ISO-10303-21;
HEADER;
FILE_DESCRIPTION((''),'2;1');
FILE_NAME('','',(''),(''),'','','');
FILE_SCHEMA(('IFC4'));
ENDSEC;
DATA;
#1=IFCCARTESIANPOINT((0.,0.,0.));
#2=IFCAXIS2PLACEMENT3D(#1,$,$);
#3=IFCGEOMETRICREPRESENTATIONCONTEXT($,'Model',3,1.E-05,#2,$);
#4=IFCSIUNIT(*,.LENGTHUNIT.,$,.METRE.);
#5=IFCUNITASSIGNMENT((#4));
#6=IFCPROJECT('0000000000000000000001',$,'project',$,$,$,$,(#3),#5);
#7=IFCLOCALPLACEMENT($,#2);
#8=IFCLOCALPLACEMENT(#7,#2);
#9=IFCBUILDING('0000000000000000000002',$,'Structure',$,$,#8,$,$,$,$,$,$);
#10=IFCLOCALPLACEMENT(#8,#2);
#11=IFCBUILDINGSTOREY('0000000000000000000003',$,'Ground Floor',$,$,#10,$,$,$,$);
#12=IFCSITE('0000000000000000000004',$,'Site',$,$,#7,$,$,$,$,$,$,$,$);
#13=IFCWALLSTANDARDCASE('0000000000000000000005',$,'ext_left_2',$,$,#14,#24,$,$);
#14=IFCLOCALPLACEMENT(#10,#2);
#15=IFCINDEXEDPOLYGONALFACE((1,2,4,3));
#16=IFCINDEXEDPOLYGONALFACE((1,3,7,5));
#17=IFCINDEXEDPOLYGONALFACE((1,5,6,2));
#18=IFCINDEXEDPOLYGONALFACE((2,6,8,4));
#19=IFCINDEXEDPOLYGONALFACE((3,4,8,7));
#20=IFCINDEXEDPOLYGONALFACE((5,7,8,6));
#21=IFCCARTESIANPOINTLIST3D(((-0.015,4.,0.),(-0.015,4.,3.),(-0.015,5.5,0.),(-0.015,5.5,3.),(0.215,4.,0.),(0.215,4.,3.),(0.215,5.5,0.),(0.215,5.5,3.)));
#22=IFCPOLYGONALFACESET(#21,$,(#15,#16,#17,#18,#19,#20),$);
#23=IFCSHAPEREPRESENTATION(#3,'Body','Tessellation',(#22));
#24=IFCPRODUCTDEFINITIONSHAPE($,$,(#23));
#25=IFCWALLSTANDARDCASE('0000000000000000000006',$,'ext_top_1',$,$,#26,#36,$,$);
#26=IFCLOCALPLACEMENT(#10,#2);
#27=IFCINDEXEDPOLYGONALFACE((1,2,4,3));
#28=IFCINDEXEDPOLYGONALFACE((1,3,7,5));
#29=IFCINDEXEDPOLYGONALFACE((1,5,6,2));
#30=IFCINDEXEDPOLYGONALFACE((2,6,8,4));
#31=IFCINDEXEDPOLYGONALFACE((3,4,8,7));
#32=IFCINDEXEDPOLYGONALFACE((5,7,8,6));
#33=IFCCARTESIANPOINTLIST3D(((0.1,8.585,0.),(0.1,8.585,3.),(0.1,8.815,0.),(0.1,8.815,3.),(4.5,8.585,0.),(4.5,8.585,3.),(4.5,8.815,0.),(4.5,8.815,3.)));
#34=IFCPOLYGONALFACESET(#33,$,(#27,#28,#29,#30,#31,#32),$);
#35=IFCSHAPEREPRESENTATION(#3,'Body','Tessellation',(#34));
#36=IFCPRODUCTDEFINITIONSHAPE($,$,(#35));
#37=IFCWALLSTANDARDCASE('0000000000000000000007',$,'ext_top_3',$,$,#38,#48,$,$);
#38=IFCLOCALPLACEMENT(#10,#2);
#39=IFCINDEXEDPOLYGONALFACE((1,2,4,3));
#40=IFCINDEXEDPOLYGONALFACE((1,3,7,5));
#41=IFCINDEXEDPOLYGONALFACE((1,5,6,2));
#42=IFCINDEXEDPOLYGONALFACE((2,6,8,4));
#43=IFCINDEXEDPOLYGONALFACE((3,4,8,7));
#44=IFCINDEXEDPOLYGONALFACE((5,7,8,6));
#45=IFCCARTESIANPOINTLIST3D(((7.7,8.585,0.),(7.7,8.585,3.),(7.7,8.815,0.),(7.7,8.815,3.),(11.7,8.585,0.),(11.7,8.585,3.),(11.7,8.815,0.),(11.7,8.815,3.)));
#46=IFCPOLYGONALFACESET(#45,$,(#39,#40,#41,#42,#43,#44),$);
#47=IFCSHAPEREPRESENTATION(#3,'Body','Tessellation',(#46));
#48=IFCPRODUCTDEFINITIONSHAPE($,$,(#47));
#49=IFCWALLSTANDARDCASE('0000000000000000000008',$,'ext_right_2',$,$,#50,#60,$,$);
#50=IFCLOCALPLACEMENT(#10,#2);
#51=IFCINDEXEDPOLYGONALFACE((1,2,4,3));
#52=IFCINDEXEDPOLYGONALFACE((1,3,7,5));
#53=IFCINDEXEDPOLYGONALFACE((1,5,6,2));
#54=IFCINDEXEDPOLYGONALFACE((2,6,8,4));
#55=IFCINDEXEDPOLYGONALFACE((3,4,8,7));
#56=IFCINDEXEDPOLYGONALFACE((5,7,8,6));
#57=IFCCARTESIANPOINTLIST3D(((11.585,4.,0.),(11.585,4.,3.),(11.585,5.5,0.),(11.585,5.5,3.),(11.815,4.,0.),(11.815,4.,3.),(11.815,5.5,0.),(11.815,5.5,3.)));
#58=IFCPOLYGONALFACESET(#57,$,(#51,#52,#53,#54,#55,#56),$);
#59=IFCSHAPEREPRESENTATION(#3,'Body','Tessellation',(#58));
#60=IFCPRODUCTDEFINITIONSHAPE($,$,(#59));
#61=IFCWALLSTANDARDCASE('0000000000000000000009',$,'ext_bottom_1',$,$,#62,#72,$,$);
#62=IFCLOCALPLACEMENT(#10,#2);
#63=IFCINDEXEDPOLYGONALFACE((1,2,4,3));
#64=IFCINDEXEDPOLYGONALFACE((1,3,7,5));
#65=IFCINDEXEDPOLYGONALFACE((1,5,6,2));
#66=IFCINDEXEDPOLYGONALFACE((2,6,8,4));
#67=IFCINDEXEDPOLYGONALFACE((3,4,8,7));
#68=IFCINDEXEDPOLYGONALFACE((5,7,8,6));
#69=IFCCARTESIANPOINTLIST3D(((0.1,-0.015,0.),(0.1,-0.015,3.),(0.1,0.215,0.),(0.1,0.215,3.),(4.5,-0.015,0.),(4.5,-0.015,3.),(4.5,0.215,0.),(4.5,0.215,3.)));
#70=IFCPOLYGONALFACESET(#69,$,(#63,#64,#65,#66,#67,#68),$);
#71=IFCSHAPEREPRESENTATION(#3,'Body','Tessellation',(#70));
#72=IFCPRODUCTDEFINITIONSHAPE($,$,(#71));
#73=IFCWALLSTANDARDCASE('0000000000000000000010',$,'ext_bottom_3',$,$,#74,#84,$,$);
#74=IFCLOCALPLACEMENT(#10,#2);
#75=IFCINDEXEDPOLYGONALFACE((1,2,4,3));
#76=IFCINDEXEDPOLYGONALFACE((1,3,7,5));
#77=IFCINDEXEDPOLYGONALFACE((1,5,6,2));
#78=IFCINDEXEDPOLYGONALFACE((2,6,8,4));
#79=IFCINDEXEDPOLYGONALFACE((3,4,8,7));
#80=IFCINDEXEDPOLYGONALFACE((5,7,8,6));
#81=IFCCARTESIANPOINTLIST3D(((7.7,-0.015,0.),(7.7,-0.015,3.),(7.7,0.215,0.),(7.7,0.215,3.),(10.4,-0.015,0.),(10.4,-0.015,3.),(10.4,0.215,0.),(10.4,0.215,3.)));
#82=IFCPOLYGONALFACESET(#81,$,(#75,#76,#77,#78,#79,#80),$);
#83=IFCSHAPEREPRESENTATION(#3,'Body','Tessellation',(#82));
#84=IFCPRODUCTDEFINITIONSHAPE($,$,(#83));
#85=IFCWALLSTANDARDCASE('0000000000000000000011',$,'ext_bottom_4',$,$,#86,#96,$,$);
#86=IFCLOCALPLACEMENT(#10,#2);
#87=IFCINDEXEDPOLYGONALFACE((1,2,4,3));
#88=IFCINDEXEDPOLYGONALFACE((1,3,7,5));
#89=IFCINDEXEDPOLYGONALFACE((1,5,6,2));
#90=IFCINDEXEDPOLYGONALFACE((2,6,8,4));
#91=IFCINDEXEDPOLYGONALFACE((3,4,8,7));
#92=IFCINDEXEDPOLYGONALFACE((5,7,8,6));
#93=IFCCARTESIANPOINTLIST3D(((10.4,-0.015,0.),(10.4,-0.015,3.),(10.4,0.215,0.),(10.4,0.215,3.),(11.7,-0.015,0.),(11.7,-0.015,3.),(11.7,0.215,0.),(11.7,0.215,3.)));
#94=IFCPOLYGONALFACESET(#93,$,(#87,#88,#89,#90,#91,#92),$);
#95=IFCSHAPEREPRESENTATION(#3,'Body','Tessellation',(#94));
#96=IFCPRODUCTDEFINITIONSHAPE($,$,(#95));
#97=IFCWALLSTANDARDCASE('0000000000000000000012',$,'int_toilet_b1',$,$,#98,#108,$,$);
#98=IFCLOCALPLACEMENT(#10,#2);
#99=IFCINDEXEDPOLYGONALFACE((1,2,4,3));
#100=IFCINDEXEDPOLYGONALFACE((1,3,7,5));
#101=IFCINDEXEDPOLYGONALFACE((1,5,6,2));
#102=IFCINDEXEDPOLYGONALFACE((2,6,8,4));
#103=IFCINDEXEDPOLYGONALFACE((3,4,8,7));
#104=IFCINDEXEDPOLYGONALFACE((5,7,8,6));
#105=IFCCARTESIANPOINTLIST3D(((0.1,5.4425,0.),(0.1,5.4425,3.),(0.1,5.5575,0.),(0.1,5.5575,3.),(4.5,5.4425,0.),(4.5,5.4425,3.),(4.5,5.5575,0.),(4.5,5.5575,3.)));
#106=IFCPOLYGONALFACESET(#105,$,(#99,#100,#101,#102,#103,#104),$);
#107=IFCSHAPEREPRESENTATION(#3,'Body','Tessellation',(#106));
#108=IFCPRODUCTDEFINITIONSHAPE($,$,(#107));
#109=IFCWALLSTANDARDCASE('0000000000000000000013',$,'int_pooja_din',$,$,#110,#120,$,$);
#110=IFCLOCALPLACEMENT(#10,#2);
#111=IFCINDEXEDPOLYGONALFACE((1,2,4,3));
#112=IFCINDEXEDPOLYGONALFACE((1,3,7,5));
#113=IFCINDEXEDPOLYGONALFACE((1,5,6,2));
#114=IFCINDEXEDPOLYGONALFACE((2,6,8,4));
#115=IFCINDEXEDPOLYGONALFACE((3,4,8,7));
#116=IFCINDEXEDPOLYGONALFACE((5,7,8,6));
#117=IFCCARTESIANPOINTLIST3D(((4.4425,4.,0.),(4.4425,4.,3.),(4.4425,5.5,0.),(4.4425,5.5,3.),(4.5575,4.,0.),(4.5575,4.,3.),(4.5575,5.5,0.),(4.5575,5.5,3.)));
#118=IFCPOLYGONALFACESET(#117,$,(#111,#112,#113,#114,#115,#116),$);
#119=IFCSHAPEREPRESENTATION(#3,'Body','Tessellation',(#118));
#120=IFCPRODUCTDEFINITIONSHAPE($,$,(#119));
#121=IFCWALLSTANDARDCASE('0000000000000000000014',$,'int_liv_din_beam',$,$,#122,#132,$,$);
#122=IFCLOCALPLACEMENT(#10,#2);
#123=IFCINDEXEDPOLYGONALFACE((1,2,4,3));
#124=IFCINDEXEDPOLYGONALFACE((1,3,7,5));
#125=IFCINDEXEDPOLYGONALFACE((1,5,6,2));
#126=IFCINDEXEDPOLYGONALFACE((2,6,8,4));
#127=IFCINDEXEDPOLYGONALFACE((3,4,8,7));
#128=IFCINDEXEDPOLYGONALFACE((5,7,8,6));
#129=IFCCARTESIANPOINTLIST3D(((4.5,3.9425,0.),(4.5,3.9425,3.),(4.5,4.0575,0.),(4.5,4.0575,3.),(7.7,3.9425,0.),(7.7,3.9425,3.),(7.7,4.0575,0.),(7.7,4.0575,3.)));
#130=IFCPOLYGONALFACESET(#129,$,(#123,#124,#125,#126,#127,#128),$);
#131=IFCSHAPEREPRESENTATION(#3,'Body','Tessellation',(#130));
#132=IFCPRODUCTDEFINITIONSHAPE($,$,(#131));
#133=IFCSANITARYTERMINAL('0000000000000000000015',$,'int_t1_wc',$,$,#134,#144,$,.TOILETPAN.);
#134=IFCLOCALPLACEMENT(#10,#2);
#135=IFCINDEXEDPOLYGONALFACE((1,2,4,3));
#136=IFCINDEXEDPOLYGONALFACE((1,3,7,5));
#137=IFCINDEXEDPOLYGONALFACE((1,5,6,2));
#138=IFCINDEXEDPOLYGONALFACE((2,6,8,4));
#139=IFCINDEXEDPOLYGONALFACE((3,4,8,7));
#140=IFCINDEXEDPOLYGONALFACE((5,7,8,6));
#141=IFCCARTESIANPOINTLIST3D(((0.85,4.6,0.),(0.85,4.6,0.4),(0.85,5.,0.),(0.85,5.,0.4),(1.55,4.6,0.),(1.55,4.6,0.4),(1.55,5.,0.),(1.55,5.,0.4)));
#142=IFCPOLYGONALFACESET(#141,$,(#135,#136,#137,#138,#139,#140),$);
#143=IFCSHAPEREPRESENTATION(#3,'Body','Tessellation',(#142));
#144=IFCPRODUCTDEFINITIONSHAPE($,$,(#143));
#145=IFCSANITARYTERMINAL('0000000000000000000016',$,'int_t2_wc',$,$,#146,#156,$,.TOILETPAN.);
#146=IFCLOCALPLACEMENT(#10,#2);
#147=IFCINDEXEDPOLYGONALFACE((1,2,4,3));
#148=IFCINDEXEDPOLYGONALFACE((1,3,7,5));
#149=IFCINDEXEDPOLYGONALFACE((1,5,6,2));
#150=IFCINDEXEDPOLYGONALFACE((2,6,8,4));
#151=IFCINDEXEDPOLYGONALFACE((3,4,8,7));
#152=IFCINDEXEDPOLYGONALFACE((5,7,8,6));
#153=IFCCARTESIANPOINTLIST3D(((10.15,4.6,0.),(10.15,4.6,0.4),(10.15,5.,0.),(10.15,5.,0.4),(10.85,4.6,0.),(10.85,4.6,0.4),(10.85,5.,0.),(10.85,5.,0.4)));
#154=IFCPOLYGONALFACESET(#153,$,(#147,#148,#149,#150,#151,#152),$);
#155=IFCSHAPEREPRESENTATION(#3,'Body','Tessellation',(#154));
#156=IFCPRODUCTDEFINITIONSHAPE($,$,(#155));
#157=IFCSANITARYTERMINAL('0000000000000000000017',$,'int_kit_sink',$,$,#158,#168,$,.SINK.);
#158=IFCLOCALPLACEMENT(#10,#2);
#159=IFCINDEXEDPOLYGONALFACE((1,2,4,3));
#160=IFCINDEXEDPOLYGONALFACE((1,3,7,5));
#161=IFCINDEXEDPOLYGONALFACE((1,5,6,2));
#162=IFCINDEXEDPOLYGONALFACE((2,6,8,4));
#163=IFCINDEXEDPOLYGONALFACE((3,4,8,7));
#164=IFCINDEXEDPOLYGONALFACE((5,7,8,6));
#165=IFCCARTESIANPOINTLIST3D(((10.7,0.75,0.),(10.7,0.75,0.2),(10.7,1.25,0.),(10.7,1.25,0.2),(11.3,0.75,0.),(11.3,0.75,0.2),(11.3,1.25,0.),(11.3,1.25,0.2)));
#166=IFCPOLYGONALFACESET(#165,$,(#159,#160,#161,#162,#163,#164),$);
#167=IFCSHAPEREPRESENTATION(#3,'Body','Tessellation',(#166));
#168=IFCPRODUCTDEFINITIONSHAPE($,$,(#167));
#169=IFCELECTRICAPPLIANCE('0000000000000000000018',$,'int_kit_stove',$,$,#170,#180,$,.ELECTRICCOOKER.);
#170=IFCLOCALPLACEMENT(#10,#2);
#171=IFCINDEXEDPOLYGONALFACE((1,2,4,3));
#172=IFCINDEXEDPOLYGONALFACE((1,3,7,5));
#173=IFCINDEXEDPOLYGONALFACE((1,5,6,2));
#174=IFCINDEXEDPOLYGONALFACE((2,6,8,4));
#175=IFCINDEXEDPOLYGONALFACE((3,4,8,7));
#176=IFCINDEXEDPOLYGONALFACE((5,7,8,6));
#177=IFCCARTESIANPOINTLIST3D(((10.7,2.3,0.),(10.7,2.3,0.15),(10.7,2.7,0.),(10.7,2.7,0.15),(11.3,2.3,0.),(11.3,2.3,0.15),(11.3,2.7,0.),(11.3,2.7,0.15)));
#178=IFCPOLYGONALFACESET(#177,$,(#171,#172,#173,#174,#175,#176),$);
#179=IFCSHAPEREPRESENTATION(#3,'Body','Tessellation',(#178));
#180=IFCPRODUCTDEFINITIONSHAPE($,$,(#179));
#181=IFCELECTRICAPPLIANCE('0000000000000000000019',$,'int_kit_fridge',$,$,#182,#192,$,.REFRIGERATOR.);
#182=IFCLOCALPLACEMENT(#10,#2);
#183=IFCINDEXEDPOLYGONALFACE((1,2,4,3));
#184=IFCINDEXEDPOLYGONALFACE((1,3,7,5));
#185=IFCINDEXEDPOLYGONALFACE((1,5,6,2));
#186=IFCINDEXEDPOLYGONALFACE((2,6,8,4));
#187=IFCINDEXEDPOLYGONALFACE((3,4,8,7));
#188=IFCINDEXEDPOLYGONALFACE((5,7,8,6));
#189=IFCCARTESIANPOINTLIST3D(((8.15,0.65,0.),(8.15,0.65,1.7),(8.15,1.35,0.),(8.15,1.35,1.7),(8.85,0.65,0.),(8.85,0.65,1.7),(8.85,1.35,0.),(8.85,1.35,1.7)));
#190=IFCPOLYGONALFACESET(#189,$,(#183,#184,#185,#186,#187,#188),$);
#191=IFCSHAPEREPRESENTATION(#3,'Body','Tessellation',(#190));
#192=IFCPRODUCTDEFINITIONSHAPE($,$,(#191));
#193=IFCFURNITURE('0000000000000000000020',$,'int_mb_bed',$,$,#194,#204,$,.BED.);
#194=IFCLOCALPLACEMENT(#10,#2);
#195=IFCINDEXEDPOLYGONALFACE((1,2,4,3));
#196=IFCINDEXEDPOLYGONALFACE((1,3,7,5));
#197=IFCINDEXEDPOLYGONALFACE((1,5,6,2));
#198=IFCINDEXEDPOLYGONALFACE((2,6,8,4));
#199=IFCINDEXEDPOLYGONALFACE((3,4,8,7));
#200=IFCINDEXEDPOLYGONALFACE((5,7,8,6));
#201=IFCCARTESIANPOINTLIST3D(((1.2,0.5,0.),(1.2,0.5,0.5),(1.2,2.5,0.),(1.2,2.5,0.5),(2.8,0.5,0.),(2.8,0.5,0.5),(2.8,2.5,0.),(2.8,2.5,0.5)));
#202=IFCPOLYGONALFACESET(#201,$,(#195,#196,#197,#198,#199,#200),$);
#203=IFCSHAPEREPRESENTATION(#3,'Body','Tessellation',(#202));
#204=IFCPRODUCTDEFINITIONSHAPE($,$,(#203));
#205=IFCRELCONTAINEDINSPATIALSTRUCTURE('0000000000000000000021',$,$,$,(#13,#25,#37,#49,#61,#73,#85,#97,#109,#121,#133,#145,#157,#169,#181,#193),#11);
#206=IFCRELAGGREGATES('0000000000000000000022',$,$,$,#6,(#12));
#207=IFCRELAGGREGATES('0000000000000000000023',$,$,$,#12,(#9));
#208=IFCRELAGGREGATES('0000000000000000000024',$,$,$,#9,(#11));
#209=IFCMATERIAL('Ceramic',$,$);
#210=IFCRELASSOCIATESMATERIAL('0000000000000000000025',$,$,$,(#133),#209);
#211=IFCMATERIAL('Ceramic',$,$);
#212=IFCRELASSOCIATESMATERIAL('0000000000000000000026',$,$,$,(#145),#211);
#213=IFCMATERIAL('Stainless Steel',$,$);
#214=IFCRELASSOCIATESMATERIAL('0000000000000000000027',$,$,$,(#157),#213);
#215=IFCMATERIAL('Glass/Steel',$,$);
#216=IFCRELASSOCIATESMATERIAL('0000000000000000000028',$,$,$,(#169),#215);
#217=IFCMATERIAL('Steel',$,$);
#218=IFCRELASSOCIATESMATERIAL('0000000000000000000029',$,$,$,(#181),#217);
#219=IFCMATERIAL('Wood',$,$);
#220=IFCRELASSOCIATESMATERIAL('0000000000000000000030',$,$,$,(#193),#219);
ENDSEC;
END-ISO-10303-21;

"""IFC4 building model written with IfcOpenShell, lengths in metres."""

from ifc_helpers import new_model, si_unit, frame, origin, place, context, project, spatial, polyline, outline, extrude, material, element, save


model = new_model("IFC4")

# Units and contexts
model_context = context("Model", 3, precision=1e-05, world=origin())
ifc_project = project(units=[si_unit("LENGTHUNIT", "METRE")], contexts=[model_context])

# Site, building, storey
site_placement = place(None, origin())
site = spatial("IfcSite", under=ifc_project, at=site_placement, Name="Site")
building_placement = place(site_placement, origin())
building = spatial("IfcBuilding", under=site, at=building_placement, Name="Structure")
storey_placement = place(building_placement, origin())
storey = spatial("IfcBuildingStorey", under=building, at=storey_placement, Name="Ground Floor")

# Walls
wall_1_placement = place(storey_placement, frame((0.1, 4.0, 0.0), x_axis=(0.0, 1.0, 0.0)))
element("IfcWallStandardCase", 1, at=wall_1_placement, inside=storey, Name="ext_left_2", context=model_context, shape_type="SweptSolid", body=[
    extrude(outline(polyline([(0.0, -0.115), (1.5, -0.115), (1.5, 0.115), (0.0, 0.115), (0.0, -0.115)])), origin(), (0.0, 0.0, 1.0), 3.0),
])
wall_2_placement = place(storey_placement, frame((0.1, 8.7, 0.0), x_axis=(1.0, 0.0, 0.0)))
element("IfcWallStandardCase", 2, at=wall_2_placement, inside=storey, Name="ext_top_1", context=model_context, shape_type="SweptSolid", body=[
    extrude(outline(polyline([(0.0, -0.115), (4.4, -0.115), (4.4, 0.115), (0.0, 0.115), (0.0, -0.115)])), origin(), (0.0, 0.0, 1.0), 3.0),
])
wall_3_placement = place(storey_placement, frame((7.7, 8.7, 0.0), x_axis=(1.0, 0.0, 0.0)))
element("IfcWallStandardCase", 3, at=wall_3_placement, inside=storey, Name="ext_top_3", context=model_context, shape_type="SweptSolid", body=[
    extrude(outline(polyline([(0.0, -0.115), (4.0, -0.115), (4.0, 0.115), (0.0, 0.115), (0.0, -0.115)])), origin(), (0.0, 0.0, 1.0), 3.0),
])
wall_4_placement = place(storey_placement, frame((11.7, 5.5, 0.0), x_axis=(0.0, -1.0, 0.0)))
element("IfcWallStandardCase", 4, at=wall_4_placement, inside=storey, Name="ext_right_2", context=model_context, shape_type="SweptSolid", body=[
    extrude(outline(polyline([(0.0, -0.115), (1.5, -0.115), (1.5, 0.115), (0.0, 0.115), (0.0, -0.115)])), origin(), (0.0, 0.0, 1.0), 3.0),
])
wall_5_placement = place(storey_placement, frame((0.1, 0.1, 0.0), x_axis=(1.0, 0.0, 0.0)))
element("IfcWallStandardCase", 5, at=wall_5_placement, inside=storey, Name="ext_bottom_1", context=model_context, shape_type="SweptSolid", body=[
    extrude(outline(polyline([(0.0, -0.115), (4.4, -0.115), (4.4, 0.115), (0.0, 0.115), (0.0, -0.115)])), origin(), (0.0, 0.0, 1.0), 3.0),
])
wall_6_placement = place(storey_placement, frame((7.7, 0.1, 0.0), x_axis=(1.0, 0.0, 0.0)))
element("IfcWallStandardCase", 6, at=wall_6_placement, inside=storey, Name="ext_bottom_3", context=model_context, shape_type="SweptSolid", body=[
    extrude(outline(polyline([(0.0, -0.115), (2.7, -0.115), (2.7, 0.115), (0.0, 0.115), (0.0, -0.115)])), origin(), (0.0, 0.0, 1.0), 3.0),
])
wall_7_placement = place(storey_placement, frame((10.4, 0.1, 0.0), x_axis=(1.0, 0.0, 0.0)))
element("IfcWallStandardCase", 7, at=wall_7_placement, inside=storey, Name="ext_bottom_4", context=model_context, shape_type="SweptSolid", body=[
    extrude(outline(polyline([(0.0, -0.115), (1.3, -0.115), (1.3, 0.115), (0.0, 0.115), (0.0, -0.115)])), origin(), (0.0, 0.0, 1.0), 3.0),
])
wall_8_placement = place(storey_placement, frame((0.1, 5.5, 0.0), x_axis=(1.0, 0.0, 0.0)))
element("IfcWallStandardCase", 8, at=wall_8_placement, inside=storey, Name="int_toilet_b1", context=model_context, shape_type="SweptSolid", body=[
    extrude(outline(polyline([(0.0, -0.0575), (4.4, -0.0575), (4.4, 0.0575), (0.0, 0.0575), (0.0, -0.0575)])), origin(), (0.0, 0.0, 1.0), 3.0),
])
wall_9_placement = place(storey_placement, frame((4.5, 4.0, 0.0), x_axis=(0.0, 1.0, 0.0)))
element("IfcWallStandardCase", 9, at=wall_9_placement, inside=storey, Name="int_pooja_din", context=model_context, shape_type="SweptSolid", body=[
    extrude(outline(polyline([(0.0, -0.0575), (1.5, -0.0575), (1.5, 0.0575), (0.0, 0.0575), (0.0, -0.0575)])), origin(), (0.0, 0.0, 1.0), 3.0),
])
wall_10_placement = place(storey_placement, frame((4.5, 4.0, 0.0), x_axis=(1.0, 0.0, 0.0)))
element("IfcWallStandardCase", 10, at=wall_10_placement, inside=storey, Name="int_liv_din_beam", context=model_context, shape_type="SweptSolid", body=[
    extrude(outline(polyline([(0.0, -0.0575), (3.2, -0.0575), (3.2, 0.0575), (0.0, 0.0575), (0.0, -0.0575)])), origin(), (0.0, 0.0, 1.0), 3.0),
])

# Sanitary terminals
ifc_material_1 = material(Name="Ceramic")
sanitary_terminal_1_placement = place(storey_placement, frame((1.2, 4.8, 0.0)))
element("IfcSanitaryTerminal", 11, at=sanitary_terminal_1_placement, inside=storey, material=ifc_material_1, Name="int_t1_wc", PredefinedType="TOILETPAN", context=model_context, shape_type="SweptSolid", body=[
    extrude(outline(polyline([(-0.35, -0.2), (0.35, -0.2), (0.35, 0.2), (-0.35, 0.2), (-0.35, -0.2)])), origin(), (0.0, 0.0, 1.0), 0.4),
])
ifc_material_2 = material(Name="Ceramic")
sanitary_terminal_2_placement = place(storey_placement, frame((10.5, 4.8, 0.0)))
element("IfcSanitaryTerminal", 12, at=sanitary_terminal_2_placement, inside=storey, material=ifc_material_2, Name="int_t2_wc", PredefinedType="TOILETPAN", context=model_context, shape_type="SweptSolid", body=[
    extrude(outline(polyline([(-0.35, -0.2), (0.35, -0.2), (0.35, 0.2), (-0.35, 0.2), (-0.35, -0.2)])), origin(), (0.0, 0.0, 1.0), 0.4),
])
ifc_material_3 = material(Name="Stainless Steel")
sanitary_terminal_3_placement = place(storey_placement, frame((11.0, 1.0, 0.0)))
element("IfcSanitaryTerminal", 13, at=sanitary_terminal_3_placement, inside=storey, material=ifc_material_3, Name="int_kit_sink", PredefinedType="SINK", context=model_context, shape_type="SweptSolid", body=[
    extrude(outline(polyline([(-0.3, -0.25), (0.3, -0.25), (0.3, 0.25), (-0.3, 0.25), (-0.3, -0.25)])), origin(), (0.0, 0.0, 1.0), 0.2),
])

# Electric appliances
ifc_material_4 = material(Name="Glass/Steel")
electric_appliance_1_placement = place(storey_placement, frame((11.0, 2.5, 0.0)))
element("IfcElectricAppliance", 14, at=electric_appliance_1_placement, inside=storey, material=ifc_material_4, Name="int_kit_stove", PredefinedType="ELECTRICCOOKER", context=model_context, shape_type="SweptSolid", body=[
    extrude(outline(polyline([(-0.3, -0.2), (0.3, -0.2), (0.3, 0.2), (-0.3, 0.2), (-0.3, -0.2)])), origin(), (0.0, 0.0, 1.0), 0.15),
])
ifc_material_5 = material(Name="Steel")
electric_appliance_2_placement = place(storey_placement, frame((8.5, 1.0, 0.0)))
element("IfcElectricAppliance", 15, at=electric_appliance_2_placement, inside=storey, material=ifc_material_5, Name="int_kit_fridge", PredefinedType="REFRIGERATOR", context=model_context, shape_type="SweptSolid", body=[
    extrude(outline(polyline([(-0.35, -0.35), (0.35, -0.35), (0.35, 0.35), (-0.35, 0.35), (-0.35, -0.35)])), origin(), (0.0, 0.0, 1.0), 1.7),
])

# Furniture
ifc_material_6 = material(Name="Wood")
furniture_1_placement = place(storey_placement, frame((2.0, 1.5, 0.0)))
element("IfcFurniture", 16, at=furniture_1_placement, inside=storey, material=ifc_material_6, Name="int_mb_bed", PredefinedType="BED", context=model_context, shape_type="SweptSolid", body=[
    extrude(outline(polyline([(-0.8, -1.0), (0.8, -1.0), (0.8, 1.0), (-0.8, 1.0), (-0.8, -1.0)])), origin(), (0.0, 0.0, 1.0), 0.5),
])

save(model, "model.ifc")
